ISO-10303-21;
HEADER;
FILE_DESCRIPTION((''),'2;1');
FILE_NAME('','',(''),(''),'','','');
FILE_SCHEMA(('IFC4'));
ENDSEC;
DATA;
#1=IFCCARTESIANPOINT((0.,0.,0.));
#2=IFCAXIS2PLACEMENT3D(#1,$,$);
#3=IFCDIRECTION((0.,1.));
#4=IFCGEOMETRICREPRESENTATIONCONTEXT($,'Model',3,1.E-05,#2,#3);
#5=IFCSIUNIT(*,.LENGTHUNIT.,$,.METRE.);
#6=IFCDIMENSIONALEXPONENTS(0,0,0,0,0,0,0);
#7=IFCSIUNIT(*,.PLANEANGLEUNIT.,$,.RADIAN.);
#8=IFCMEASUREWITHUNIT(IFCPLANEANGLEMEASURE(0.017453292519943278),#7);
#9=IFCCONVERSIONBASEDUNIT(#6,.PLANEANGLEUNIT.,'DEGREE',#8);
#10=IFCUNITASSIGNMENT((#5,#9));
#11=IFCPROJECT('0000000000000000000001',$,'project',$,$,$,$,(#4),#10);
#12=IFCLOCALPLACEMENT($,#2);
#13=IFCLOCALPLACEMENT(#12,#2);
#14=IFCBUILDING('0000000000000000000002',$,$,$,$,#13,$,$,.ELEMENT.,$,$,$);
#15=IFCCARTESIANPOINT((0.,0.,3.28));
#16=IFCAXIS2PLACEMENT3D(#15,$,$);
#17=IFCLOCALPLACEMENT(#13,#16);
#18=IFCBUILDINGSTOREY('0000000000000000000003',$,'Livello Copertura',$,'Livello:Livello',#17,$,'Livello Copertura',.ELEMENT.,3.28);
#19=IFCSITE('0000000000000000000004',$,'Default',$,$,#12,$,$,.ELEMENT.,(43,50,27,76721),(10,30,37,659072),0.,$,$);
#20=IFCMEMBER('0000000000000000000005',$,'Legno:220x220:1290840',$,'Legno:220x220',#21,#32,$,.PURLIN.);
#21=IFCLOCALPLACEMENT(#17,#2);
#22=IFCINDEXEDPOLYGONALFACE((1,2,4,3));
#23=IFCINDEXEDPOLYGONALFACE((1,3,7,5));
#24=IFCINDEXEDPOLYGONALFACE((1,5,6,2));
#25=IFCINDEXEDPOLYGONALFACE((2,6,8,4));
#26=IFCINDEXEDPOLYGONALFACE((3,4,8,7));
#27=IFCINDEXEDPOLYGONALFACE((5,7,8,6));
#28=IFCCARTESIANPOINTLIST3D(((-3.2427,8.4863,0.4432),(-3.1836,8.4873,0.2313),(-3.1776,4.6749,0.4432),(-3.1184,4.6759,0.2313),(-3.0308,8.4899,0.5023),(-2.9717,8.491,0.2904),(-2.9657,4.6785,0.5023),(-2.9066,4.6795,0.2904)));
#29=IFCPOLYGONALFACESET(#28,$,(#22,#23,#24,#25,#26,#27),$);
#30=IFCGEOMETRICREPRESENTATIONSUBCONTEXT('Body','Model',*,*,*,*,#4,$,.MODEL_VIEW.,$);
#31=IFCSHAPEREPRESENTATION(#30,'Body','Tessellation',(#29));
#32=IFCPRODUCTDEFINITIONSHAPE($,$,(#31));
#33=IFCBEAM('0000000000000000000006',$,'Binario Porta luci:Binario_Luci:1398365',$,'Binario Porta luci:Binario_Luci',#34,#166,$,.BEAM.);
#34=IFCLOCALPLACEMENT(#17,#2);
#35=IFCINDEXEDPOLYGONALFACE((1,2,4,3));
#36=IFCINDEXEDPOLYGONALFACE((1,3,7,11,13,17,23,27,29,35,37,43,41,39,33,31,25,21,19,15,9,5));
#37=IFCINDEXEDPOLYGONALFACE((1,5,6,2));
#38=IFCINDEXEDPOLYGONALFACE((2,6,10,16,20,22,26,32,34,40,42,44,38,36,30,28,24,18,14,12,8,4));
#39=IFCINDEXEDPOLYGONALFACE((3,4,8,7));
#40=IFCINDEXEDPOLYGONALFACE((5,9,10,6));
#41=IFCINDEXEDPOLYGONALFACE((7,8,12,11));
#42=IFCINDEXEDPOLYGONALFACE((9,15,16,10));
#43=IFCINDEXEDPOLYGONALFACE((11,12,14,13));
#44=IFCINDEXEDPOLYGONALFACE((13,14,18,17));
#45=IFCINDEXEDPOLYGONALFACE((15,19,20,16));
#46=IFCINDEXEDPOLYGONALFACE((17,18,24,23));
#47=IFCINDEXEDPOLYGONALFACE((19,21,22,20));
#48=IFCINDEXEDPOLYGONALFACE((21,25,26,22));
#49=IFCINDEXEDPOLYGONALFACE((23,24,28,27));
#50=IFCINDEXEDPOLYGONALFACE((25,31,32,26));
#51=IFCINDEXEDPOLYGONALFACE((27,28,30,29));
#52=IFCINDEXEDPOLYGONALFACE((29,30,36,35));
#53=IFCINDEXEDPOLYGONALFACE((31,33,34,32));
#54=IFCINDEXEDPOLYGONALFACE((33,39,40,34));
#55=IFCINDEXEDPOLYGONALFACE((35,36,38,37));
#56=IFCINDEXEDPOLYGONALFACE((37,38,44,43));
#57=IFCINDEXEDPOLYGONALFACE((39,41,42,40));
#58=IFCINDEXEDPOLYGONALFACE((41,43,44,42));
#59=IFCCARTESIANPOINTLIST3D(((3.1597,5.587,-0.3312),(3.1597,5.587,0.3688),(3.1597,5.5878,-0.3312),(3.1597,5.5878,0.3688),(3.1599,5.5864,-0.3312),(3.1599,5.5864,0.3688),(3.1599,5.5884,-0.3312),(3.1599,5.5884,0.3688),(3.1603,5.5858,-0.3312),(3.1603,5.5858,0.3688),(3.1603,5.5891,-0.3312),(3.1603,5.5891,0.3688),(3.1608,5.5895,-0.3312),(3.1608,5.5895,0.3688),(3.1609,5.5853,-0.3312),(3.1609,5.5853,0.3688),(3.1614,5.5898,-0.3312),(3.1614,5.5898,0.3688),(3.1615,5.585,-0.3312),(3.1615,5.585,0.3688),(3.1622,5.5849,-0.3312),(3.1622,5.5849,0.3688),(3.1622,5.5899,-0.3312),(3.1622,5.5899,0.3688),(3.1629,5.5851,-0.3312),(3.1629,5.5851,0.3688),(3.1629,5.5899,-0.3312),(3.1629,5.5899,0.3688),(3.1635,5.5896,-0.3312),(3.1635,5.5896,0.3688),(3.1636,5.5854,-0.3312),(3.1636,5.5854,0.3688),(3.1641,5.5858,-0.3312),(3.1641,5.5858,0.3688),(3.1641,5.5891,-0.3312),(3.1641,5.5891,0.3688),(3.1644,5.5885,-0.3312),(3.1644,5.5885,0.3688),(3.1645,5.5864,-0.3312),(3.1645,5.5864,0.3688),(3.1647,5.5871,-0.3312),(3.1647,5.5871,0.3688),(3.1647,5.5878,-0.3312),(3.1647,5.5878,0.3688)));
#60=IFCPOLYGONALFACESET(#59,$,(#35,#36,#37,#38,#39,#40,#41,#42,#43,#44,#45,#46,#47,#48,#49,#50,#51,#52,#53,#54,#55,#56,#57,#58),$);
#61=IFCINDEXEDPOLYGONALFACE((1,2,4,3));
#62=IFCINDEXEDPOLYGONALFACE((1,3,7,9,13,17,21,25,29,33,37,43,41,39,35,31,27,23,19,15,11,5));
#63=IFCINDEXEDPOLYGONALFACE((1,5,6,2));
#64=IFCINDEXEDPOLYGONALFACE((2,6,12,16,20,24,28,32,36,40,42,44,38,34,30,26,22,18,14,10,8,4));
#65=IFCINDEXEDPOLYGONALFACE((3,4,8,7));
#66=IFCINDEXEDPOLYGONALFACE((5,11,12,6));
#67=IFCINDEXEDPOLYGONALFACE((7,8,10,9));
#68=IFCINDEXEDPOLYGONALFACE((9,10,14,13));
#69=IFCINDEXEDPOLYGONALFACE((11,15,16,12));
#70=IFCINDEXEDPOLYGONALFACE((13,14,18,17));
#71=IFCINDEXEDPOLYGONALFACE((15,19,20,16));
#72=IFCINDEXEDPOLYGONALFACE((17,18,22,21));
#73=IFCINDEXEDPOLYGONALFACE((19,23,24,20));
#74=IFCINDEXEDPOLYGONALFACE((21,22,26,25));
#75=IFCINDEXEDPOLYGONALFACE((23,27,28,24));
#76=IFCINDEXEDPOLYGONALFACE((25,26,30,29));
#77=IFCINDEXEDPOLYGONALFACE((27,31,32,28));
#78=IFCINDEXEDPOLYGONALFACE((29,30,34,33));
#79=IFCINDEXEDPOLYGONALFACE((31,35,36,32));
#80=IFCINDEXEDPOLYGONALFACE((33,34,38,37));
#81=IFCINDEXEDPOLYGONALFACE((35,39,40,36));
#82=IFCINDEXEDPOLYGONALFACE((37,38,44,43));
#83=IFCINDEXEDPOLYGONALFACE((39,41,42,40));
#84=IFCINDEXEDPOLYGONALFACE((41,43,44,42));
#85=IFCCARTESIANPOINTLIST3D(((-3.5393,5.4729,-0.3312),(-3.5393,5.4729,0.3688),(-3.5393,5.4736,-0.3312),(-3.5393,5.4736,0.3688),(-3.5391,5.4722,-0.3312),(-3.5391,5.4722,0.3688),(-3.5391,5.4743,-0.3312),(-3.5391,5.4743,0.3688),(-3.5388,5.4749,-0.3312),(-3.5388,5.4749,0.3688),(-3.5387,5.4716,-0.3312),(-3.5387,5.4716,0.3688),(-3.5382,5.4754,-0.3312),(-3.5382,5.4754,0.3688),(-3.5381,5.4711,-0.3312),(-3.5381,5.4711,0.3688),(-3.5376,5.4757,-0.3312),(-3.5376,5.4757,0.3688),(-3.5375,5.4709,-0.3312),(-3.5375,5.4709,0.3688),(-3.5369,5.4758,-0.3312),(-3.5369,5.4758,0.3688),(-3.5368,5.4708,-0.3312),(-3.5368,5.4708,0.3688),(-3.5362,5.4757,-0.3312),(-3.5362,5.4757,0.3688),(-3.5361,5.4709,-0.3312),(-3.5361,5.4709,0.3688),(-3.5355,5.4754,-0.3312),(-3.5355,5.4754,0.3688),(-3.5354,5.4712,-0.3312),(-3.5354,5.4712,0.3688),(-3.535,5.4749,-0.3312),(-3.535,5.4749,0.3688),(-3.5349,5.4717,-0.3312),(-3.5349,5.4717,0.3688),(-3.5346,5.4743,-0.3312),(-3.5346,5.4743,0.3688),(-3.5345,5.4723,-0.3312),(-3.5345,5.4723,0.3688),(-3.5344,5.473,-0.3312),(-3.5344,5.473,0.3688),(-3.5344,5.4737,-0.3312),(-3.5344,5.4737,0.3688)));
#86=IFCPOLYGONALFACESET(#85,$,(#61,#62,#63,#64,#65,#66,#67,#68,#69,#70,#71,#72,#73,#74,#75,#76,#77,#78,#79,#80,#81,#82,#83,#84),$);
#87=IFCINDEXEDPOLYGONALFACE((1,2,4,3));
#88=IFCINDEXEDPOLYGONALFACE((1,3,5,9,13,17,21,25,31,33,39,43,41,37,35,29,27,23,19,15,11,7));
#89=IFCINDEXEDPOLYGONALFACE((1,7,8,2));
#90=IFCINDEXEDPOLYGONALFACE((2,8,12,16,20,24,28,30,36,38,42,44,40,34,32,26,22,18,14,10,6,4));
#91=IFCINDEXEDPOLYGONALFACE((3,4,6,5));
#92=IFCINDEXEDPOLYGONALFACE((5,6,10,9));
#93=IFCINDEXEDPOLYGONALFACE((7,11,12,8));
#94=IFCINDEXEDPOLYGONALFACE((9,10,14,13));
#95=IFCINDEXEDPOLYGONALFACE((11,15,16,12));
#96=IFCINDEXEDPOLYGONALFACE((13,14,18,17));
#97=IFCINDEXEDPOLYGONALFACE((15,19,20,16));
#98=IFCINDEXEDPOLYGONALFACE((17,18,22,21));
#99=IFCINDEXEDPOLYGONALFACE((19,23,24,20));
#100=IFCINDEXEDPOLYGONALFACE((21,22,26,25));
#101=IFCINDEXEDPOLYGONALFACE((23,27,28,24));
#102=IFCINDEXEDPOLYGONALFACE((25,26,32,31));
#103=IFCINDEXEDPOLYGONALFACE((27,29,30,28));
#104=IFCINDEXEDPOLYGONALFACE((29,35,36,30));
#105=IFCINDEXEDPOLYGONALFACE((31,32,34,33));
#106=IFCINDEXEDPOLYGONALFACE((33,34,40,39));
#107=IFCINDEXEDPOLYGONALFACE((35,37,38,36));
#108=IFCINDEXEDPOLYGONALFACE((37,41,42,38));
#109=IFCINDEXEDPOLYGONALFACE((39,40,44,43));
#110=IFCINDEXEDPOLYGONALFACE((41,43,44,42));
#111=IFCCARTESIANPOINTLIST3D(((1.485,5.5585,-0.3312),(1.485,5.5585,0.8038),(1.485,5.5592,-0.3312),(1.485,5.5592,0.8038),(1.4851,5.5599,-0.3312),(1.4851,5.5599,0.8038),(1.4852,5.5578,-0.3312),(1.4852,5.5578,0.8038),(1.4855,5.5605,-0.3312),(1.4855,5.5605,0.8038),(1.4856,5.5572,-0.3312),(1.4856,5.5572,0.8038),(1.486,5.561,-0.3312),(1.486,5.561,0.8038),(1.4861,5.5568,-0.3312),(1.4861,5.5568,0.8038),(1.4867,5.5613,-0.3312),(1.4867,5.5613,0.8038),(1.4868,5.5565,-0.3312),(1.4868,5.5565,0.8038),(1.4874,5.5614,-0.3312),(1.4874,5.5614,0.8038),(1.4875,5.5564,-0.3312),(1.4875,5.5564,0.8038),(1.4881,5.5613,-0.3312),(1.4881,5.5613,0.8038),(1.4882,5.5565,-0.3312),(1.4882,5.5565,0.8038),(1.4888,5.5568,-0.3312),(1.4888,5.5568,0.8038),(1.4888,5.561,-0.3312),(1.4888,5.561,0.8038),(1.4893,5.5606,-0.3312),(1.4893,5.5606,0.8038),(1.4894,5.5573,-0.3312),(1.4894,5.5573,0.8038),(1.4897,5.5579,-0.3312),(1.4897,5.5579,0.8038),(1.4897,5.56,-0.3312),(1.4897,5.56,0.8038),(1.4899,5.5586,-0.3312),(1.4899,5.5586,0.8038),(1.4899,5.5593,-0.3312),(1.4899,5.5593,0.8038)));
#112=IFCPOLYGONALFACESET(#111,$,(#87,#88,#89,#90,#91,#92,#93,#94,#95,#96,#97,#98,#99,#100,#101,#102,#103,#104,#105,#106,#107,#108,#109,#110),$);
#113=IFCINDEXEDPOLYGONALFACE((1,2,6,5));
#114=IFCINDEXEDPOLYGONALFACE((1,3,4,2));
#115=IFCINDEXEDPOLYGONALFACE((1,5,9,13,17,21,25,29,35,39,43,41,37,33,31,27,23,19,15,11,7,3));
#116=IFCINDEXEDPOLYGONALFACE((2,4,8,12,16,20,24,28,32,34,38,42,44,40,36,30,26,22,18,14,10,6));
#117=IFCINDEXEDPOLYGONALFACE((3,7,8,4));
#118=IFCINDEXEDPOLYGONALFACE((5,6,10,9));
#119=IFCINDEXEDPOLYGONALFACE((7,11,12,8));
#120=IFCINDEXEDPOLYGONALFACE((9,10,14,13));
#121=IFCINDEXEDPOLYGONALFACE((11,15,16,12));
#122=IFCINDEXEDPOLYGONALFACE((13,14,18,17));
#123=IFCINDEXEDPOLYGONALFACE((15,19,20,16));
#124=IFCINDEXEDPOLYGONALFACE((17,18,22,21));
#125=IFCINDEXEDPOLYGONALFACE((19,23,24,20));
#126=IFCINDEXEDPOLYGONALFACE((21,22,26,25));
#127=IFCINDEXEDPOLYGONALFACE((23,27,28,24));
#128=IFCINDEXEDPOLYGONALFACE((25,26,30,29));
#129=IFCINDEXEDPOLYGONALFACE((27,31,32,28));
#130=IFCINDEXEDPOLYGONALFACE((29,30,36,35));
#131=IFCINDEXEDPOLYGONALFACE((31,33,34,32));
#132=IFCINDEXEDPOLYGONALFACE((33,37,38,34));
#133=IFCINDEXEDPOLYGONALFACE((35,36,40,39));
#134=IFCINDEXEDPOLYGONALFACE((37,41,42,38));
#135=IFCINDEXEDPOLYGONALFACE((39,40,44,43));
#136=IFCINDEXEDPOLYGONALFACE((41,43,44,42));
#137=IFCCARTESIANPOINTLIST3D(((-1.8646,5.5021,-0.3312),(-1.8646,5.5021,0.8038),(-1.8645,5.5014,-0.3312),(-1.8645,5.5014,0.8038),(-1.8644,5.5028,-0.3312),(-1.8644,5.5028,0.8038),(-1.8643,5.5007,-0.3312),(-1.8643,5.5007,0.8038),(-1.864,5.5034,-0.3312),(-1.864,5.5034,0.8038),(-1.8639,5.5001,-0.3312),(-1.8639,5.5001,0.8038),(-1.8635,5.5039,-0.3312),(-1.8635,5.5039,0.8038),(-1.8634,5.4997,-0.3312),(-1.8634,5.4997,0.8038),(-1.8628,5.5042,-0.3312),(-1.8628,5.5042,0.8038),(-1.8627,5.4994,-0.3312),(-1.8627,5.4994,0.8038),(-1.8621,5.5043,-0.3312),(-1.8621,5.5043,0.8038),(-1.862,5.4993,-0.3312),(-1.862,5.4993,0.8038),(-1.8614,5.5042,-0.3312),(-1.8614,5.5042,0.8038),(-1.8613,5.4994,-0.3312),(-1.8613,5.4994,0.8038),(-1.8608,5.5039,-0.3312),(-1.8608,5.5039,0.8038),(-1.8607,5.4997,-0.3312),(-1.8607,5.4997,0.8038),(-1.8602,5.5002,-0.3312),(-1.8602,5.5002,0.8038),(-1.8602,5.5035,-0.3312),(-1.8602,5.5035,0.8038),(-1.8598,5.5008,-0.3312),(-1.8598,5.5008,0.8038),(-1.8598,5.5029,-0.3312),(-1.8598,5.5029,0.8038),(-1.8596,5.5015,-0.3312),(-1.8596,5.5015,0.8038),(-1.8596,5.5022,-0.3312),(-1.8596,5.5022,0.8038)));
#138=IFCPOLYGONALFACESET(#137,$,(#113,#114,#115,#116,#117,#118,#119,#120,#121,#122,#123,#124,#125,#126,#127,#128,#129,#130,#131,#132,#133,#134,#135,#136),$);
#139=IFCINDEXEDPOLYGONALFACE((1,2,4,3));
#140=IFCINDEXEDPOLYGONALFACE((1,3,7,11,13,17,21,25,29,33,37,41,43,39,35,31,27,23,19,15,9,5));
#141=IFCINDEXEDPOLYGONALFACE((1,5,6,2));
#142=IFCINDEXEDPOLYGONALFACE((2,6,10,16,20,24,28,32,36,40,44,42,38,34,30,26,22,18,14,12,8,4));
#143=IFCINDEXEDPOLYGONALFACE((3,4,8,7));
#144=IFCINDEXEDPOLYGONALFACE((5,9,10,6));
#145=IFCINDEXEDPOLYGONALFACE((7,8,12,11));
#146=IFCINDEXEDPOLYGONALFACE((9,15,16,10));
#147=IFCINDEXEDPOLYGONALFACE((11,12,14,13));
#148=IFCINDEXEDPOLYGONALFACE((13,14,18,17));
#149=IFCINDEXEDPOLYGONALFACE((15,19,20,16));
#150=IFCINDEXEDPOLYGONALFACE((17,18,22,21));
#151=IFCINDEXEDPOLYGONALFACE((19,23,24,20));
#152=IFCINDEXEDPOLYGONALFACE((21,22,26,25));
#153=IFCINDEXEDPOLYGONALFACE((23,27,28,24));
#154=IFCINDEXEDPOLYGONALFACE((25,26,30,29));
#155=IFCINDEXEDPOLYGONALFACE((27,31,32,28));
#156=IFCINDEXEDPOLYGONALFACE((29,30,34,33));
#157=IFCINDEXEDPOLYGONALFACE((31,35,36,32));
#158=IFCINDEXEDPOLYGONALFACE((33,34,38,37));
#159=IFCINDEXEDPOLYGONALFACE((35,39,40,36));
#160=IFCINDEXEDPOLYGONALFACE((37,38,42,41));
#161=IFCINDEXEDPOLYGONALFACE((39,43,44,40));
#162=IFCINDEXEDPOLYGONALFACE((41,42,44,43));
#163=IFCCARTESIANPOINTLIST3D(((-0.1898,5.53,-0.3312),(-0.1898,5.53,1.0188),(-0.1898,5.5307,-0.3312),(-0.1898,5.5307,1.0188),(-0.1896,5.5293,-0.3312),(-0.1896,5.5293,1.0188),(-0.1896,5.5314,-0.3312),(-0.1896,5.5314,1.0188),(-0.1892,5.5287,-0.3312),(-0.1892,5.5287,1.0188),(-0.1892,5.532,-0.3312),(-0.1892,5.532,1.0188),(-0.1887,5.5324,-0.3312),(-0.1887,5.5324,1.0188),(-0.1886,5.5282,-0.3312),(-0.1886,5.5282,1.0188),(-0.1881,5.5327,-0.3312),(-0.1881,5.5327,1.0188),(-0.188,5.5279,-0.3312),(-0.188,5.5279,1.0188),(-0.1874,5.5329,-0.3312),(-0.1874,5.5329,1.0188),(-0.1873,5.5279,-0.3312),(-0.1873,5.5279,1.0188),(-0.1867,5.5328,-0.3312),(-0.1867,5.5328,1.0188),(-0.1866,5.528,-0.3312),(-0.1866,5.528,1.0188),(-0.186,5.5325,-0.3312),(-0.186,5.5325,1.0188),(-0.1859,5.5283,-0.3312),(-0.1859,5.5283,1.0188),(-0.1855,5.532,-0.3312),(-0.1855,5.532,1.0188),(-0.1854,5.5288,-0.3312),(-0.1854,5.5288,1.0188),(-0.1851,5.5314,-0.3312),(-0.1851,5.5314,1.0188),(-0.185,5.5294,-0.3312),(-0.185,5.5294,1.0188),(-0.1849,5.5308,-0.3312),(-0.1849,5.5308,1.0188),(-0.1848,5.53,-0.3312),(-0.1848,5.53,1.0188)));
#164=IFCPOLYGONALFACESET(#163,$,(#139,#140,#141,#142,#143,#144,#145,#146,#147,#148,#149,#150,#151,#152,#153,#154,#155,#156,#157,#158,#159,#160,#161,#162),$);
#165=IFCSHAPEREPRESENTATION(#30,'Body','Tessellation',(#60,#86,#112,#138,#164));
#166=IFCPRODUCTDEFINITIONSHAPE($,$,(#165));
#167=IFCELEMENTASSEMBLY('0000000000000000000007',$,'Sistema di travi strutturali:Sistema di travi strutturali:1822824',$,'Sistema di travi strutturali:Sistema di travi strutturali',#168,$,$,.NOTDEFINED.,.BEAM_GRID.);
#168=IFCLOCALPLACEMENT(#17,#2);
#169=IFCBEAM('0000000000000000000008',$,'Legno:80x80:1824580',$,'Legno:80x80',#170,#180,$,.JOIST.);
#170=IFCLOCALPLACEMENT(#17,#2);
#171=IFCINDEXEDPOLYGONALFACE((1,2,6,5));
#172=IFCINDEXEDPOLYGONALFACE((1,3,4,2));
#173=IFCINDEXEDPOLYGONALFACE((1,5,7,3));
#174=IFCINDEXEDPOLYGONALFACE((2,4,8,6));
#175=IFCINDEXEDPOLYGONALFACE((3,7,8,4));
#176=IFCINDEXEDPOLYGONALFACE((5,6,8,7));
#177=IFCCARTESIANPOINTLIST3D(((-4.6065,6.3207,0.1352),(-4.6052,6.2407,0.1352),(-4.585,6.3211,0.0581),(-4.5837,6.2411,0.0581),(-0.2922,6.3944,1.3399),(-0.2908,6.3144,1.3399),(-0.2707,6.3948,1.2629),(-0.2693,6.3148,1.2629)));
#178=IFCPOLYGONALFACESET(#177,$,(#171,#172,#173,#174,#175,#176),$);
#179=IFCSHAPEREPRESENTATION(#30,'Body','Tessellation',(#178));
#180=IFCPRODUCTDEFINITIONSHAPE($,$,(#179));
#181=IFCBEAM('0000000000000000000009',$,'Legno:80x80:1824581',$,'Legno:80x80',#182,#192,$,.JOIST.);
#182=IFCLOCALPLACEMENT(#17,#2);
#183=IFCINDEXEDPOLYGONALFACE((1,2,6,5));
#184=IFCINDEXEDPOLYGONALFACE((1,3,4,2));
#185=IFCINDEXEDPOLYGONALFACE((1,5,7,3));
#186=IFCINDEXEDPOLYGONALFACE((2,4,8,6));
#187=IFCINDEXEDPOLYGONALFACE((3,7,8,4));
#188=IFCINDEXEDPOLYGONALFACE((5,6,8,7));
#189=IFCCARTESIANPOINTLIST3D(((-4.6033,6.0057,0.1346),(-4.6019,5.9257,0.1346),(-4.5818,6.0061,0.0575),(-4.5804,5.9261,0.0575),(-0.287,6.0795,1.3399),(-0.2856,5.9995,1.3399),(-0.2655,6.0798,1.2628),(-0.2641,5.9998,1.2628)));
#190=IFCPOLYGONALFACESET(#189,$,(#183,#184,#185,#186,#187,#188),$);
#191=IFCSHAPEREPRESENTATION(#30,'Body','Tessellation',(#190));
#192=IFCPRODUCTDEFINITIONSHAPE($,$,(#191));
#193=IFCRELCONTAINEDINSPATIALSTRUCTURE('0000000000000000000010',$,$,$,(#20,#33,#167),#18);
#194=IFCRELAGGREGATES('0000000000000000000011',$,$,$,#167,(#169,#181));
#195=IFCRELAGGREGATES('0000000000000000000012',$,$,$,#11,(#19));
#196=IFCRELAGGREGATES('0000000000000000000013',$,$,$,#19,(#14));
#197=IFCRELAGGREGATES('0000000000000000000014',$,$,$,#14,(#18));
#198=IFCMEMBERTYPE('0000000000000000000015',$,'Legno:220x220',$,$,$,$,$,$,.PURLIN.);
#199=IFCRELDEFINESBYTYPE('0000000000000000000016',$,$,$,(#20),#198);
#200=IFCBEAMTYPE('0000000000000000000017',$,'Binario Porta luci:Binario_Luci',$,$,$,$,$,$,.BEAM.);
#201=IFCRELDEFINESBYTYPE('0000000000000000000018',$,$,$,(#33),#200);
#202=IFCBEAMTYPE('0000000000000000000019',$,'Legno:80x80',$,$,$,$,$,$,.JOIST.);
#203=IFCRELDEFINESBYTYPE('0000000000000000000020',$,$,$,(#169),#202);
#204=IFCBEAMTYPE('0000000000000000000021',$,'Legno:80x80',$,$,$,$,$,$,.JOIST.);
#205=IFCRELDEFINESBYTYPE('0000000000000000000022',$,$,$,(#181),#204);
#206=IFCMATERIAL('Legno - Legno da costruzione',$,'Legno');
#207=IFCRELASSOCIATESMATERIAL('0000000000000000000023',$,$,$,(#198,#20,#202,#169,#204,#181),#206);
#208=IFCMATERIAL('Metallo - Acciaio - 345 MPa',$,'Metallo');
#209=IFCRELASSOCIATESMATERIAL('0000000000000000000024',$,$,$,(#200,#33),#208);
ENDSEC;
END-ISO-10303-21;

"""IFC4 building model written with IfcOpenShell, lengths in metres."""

from ifc_helpers import new_model, entity, si_unit, converted_unit, direction, frame, origin, place, context, subcontext, project, spatial, arc, indexed_curve, outline, extrude, source, transform, mapped, material, type_object, type_shapes, element, aggregate, save


model = new_model("IFC4")

# Units and contexts
model_context = context("Model", 3, precision=1e-05, world=origin(), true_north=direction((0.0, 1.0)))
body_context = subcontext(model_context, "Body", "Model", "MODEL_VIEW")
ifc_project = project(units=[si_unit("LENGTHUNIT", "METRE"), converted_unit("PLANEANGLEUNIT", "DEGREE", entity("IfcPlaneAngleMeasure", 0.017453292519943278), si_unit("PLANEANGLEUNIT", "RADIAN"), dimensions=[0, 0, 0, 0, 0, 0, 0])], contexts=[model_context])

# Site, building, storey
site_placement = place(None, origin())
site = spatial("IfcSite", under=ifc_project, at=site_placement, Name="Default", CompositionType="ELEMENT", RefLatitude=(43, 50, 27, 76721), RefLongitude=(10, 30, 37, 659072), RefElevation=0.0)
building_placement = place(site_placement, origin())
building = spatial("IfcBuilding", under=site, at=building_placement, CompositionType="ELEMENT")
storey_placement = place(building_placement, frame((0.0, 0.0, 3.28)))
storey = spatial("IfcBuildingStorey", under=building, at=storey_placement, Name="Livello Copertura", ObjectType="Livello:Livello", LongName="Livello Copertura", CompositionType="ELEMENT", Elevation=3.28)

# Member
ifc_material_1 = material(Name="Legno - Legno da costruzione", Category="Legno")
member_type = type_object("IfcMemberType", Name="Legno:220x220", PredefinedType="PURLIN", material=ifc_material_1)
shared_shape_1 = source(origin(), body_context, "Body", "SweptSolid", [
    extrude(outline(indexed_curve([(-1.906, -0.11), (1.906, -0.11), (1.906, 0.11), (-1.906, 0.11), (-1.906, -0.11)], self_intersect=False)), frame((0.0, 0.0, -0.11), z_axis=(0.0, 0.0, 1.0), x_axis=(-1.0, 0.0, 0.0)), (0.0, 0.0, 1.0), 0.22),
])
type_shapes(member_type, [shared_shape_1])
member_placement = place(storey_placement, frame((-3.0746, 6.5829, 0.3668), z_axis=(-0.268881, -0.004594, 0.963163), x_axis=(0.017085, -0.999854, 0.0)))
element("IfcMember", 1, at=member_placement, inside=storey, type_object=member_type, material=ifc_material_1, Name="Legno:220x220:1290840", ObjectType="Legno:220x220", PredefinedType="PURLIN", context=body_context, shape_type="MappedRepresentation", body=[
    mapped(shared_shape_1, transform((0.0, 0.0, 0.0), scale=1.0)),
])

# Beam
ifc_material_2 = material(Name="Metallo - Acciaio - 345 MPa", Category="Metallo")
beam_type_1 = type_object("IfcBeamType", Name="Binario Porta luci:Binario_Luci", PredefinedType="BEAM", material=ifc_material_2)
shared_shape_2 = source(origin(), body_context, "Body", "SweptSolid", [
    extrude(outline(indexed_curve([(-0.0025, 0.0), (0.0, -0.0025), (0.0025, 0.0), (0.0, 0.0025)], segments=[arc(1, 2, 3), arc(3, 4, 1)], self_intersect=False)), frame((3.35, 0.0, 0.018), z_axis=(0.0, 0.0, 1.0), x_axis=(0.0, -1.0, 0.0)), (0.0, 0.0, 1.0), 0.7),
    extrude(outline(indexed_curve([(-0.0025, 0.0), (0.0, -0.0025), (0.0025, 0.0), (0.0, 0.0025)], segments=[arc(1, 2, 3), arc(3, 4, 1)], self_intersect=False)), frame((-3.35, 0.0, 0.018), z_axis=(0.0, 0.0, 1.0), x_axis=(0.0, -1.0, 0.0)), (0.0, 0.0, 1.0), 0.7),
    extrude(outline(indexed_curve([(-0.0025, 0.0), (0.0, -0.0025), (0.0025, 0.0), (0.0, 0.0025)], segments=[arc(1, 2, 3), arc(3, 4, 1)], self_intersect=False)), frame((1.675, 0.0, 0.018), z_axis=(0.0, 0.0, 1.0), x_axis=(0.0, -1.0, 0.0)), (0.0, 0.0, 1.0), 1.135),
    extrude(outline(indexed_curve([(-0.0025, 0.0), (0.0, -0.0025), (0.0025, 0.0), (0.0, 0.0025)], segments=[arc(1, 2, 3), arc(3, 4, 1)], self_intersect=False)), frame((-1.675, 0.0, 0.018), z_axis=(0.0, 0.0, 1.0), x_axis=(0.0, -1.0, 0.0)), (0.0, 0.0, 1.0), 1.135),
    extrude(outline(indexed_curve([(-0.0025, 0.0), (0.0, -0.0025), (0.0025, 0.0), (0.0, 0.0025)], segments=[arc(1, 2, 3), arc(3, 4, 1)], self_intersect=False)), frame((0.0, 0.0, 0.018), z_axis=(0.0, 0.0, 1.0), x_axis=(0.0, -1.0, 0.0)), (0.0, 0.0, 1.0), 1.35),
])
type_shapes(beam_type_1, [shared_shape_2])
beam_1_placement = place(storey_placement, frame((-0.1873, 5.5304, -0.3492), z_axis=(0.0, 0.0, 1.0), x_axis=(0.999855, 0.017041, 0.0)))
element("IfcBeam", 2, at=beam_1_placement, inside=storey, type_object=beam_type_1, material=ifc_material_2, Name="Binario Porta luci:Binario_Luci:1398365", ObjectType="Binario Porta luci:Binario_Luci", PredefinedType="BEAM", context=body_context, shape_type="MappedRepresentation", body=[
    mapped(shared_shape_2, transform((0.0, 0.0, 0.0), scale=1.0)),
])

# Element assembly, beams
assembly_1_placement = place(storey_placement, origin())
assembly_1 = element("IfcElementAssembly", 3, at=assembly_1_placement, inside=storey, Name="Sistema di travi strutturali:Sistema di travi strutturali:1822824", ObjectType="Sistema di travi strutturali:Sistema di travi strutturali", AssemblyPlace="NOTDEFINED", PredefinedType="BEAM_GRID")
beam_type_2 = type_object("IfcBeamType", Name="Legno:80x80", PredefinedType="JOIST", material=ifc_material_1)
shared_shape_3 = source(origin(), body_context, "Body", "SweptSolid", [
    extrude(outline(indexed_curve([(-2.24, -0.04), (2.24, -0.04), (2.24, 0.04), (-2.24, 0.04), (-2.24, -0.04)], self_intersect=False)), frame((0.0, 0.0, -0.04), z_axis=(0.0, 0.0, 1.0), x_axis=(-1.0, 0.0, 0.0)), (0.0, 0.0, 1.0), 0.08),
])
type_shapes(beam_type_2, [shared_shape_3])
beam_2_placement = place(assembly_1_placement, frame((-2.4379, 6.3177, 0.699), z_axis=(-0.268881, -0.004594, 0.963163), x_axis=(0.963022, 0.016456, 0.26892)))
beam_2 = element("IfcBeam", 4, at=beam_2_placement, type_object=beam_type_2, material=ifc_material_1, Name="Legno:80x80:1824580", ObjectType="Legno:80x80", PredefinedType="JOIST", context=body_context, shape_type="MappedRepresentation", body=[
    mapped(shared_shape_3, transform((0.0, 0.0, 0.0), scale=1.0)),
])
beam_type_3 = type_object("IfcBeamType", Name="Legno:80x80", PredefinedType="JOIST", material=ifc_material_1)
shared_shape_4 = source(origin(), body_context, "Body", "SweptSolid", [
    extrude(outline(indexed_curve([(-2.241, -0.04), (2.241, -0.04), (2.241, 0.04), (-2.241, 0.04), (-2.241, -0.04)], self_intersect=False)), frame((0.0, 0.0, -0.04), z_axis=(0.0, 0.0, 1.0), x_axis=(-1.0, 0.0, 0.0)), (0.0, 0.0, 1.0), 0.08),
])
type_shapes(beam_type_3, [shared_shape_4])
beam_3_placement = place(assembly_1_placement, frame((-2.4337, 6.0028, 0.6987), z_axis=(-0.268881, -0.004594, 0.963163), x_axis=(0.963022, 0.016456, 0.26892)))
beam_3 = element("IfcBeam", 5, at=beam_3_placement, type_object=beam_type_3, material=ifc_material_1, Name="Legno:80x80:1824581", ObjectType="Legno:80x80", PredefinedType="JOIST", context=body_context, shape_type="MappedRepresentation", body=[
    mapped(shared_shape_4, transform((0.0, 0.0, 0.0), scale=1.0)),
])
aggregate(assembly_1, [beam_2, beam_3])

save(model, "model.ifc")
